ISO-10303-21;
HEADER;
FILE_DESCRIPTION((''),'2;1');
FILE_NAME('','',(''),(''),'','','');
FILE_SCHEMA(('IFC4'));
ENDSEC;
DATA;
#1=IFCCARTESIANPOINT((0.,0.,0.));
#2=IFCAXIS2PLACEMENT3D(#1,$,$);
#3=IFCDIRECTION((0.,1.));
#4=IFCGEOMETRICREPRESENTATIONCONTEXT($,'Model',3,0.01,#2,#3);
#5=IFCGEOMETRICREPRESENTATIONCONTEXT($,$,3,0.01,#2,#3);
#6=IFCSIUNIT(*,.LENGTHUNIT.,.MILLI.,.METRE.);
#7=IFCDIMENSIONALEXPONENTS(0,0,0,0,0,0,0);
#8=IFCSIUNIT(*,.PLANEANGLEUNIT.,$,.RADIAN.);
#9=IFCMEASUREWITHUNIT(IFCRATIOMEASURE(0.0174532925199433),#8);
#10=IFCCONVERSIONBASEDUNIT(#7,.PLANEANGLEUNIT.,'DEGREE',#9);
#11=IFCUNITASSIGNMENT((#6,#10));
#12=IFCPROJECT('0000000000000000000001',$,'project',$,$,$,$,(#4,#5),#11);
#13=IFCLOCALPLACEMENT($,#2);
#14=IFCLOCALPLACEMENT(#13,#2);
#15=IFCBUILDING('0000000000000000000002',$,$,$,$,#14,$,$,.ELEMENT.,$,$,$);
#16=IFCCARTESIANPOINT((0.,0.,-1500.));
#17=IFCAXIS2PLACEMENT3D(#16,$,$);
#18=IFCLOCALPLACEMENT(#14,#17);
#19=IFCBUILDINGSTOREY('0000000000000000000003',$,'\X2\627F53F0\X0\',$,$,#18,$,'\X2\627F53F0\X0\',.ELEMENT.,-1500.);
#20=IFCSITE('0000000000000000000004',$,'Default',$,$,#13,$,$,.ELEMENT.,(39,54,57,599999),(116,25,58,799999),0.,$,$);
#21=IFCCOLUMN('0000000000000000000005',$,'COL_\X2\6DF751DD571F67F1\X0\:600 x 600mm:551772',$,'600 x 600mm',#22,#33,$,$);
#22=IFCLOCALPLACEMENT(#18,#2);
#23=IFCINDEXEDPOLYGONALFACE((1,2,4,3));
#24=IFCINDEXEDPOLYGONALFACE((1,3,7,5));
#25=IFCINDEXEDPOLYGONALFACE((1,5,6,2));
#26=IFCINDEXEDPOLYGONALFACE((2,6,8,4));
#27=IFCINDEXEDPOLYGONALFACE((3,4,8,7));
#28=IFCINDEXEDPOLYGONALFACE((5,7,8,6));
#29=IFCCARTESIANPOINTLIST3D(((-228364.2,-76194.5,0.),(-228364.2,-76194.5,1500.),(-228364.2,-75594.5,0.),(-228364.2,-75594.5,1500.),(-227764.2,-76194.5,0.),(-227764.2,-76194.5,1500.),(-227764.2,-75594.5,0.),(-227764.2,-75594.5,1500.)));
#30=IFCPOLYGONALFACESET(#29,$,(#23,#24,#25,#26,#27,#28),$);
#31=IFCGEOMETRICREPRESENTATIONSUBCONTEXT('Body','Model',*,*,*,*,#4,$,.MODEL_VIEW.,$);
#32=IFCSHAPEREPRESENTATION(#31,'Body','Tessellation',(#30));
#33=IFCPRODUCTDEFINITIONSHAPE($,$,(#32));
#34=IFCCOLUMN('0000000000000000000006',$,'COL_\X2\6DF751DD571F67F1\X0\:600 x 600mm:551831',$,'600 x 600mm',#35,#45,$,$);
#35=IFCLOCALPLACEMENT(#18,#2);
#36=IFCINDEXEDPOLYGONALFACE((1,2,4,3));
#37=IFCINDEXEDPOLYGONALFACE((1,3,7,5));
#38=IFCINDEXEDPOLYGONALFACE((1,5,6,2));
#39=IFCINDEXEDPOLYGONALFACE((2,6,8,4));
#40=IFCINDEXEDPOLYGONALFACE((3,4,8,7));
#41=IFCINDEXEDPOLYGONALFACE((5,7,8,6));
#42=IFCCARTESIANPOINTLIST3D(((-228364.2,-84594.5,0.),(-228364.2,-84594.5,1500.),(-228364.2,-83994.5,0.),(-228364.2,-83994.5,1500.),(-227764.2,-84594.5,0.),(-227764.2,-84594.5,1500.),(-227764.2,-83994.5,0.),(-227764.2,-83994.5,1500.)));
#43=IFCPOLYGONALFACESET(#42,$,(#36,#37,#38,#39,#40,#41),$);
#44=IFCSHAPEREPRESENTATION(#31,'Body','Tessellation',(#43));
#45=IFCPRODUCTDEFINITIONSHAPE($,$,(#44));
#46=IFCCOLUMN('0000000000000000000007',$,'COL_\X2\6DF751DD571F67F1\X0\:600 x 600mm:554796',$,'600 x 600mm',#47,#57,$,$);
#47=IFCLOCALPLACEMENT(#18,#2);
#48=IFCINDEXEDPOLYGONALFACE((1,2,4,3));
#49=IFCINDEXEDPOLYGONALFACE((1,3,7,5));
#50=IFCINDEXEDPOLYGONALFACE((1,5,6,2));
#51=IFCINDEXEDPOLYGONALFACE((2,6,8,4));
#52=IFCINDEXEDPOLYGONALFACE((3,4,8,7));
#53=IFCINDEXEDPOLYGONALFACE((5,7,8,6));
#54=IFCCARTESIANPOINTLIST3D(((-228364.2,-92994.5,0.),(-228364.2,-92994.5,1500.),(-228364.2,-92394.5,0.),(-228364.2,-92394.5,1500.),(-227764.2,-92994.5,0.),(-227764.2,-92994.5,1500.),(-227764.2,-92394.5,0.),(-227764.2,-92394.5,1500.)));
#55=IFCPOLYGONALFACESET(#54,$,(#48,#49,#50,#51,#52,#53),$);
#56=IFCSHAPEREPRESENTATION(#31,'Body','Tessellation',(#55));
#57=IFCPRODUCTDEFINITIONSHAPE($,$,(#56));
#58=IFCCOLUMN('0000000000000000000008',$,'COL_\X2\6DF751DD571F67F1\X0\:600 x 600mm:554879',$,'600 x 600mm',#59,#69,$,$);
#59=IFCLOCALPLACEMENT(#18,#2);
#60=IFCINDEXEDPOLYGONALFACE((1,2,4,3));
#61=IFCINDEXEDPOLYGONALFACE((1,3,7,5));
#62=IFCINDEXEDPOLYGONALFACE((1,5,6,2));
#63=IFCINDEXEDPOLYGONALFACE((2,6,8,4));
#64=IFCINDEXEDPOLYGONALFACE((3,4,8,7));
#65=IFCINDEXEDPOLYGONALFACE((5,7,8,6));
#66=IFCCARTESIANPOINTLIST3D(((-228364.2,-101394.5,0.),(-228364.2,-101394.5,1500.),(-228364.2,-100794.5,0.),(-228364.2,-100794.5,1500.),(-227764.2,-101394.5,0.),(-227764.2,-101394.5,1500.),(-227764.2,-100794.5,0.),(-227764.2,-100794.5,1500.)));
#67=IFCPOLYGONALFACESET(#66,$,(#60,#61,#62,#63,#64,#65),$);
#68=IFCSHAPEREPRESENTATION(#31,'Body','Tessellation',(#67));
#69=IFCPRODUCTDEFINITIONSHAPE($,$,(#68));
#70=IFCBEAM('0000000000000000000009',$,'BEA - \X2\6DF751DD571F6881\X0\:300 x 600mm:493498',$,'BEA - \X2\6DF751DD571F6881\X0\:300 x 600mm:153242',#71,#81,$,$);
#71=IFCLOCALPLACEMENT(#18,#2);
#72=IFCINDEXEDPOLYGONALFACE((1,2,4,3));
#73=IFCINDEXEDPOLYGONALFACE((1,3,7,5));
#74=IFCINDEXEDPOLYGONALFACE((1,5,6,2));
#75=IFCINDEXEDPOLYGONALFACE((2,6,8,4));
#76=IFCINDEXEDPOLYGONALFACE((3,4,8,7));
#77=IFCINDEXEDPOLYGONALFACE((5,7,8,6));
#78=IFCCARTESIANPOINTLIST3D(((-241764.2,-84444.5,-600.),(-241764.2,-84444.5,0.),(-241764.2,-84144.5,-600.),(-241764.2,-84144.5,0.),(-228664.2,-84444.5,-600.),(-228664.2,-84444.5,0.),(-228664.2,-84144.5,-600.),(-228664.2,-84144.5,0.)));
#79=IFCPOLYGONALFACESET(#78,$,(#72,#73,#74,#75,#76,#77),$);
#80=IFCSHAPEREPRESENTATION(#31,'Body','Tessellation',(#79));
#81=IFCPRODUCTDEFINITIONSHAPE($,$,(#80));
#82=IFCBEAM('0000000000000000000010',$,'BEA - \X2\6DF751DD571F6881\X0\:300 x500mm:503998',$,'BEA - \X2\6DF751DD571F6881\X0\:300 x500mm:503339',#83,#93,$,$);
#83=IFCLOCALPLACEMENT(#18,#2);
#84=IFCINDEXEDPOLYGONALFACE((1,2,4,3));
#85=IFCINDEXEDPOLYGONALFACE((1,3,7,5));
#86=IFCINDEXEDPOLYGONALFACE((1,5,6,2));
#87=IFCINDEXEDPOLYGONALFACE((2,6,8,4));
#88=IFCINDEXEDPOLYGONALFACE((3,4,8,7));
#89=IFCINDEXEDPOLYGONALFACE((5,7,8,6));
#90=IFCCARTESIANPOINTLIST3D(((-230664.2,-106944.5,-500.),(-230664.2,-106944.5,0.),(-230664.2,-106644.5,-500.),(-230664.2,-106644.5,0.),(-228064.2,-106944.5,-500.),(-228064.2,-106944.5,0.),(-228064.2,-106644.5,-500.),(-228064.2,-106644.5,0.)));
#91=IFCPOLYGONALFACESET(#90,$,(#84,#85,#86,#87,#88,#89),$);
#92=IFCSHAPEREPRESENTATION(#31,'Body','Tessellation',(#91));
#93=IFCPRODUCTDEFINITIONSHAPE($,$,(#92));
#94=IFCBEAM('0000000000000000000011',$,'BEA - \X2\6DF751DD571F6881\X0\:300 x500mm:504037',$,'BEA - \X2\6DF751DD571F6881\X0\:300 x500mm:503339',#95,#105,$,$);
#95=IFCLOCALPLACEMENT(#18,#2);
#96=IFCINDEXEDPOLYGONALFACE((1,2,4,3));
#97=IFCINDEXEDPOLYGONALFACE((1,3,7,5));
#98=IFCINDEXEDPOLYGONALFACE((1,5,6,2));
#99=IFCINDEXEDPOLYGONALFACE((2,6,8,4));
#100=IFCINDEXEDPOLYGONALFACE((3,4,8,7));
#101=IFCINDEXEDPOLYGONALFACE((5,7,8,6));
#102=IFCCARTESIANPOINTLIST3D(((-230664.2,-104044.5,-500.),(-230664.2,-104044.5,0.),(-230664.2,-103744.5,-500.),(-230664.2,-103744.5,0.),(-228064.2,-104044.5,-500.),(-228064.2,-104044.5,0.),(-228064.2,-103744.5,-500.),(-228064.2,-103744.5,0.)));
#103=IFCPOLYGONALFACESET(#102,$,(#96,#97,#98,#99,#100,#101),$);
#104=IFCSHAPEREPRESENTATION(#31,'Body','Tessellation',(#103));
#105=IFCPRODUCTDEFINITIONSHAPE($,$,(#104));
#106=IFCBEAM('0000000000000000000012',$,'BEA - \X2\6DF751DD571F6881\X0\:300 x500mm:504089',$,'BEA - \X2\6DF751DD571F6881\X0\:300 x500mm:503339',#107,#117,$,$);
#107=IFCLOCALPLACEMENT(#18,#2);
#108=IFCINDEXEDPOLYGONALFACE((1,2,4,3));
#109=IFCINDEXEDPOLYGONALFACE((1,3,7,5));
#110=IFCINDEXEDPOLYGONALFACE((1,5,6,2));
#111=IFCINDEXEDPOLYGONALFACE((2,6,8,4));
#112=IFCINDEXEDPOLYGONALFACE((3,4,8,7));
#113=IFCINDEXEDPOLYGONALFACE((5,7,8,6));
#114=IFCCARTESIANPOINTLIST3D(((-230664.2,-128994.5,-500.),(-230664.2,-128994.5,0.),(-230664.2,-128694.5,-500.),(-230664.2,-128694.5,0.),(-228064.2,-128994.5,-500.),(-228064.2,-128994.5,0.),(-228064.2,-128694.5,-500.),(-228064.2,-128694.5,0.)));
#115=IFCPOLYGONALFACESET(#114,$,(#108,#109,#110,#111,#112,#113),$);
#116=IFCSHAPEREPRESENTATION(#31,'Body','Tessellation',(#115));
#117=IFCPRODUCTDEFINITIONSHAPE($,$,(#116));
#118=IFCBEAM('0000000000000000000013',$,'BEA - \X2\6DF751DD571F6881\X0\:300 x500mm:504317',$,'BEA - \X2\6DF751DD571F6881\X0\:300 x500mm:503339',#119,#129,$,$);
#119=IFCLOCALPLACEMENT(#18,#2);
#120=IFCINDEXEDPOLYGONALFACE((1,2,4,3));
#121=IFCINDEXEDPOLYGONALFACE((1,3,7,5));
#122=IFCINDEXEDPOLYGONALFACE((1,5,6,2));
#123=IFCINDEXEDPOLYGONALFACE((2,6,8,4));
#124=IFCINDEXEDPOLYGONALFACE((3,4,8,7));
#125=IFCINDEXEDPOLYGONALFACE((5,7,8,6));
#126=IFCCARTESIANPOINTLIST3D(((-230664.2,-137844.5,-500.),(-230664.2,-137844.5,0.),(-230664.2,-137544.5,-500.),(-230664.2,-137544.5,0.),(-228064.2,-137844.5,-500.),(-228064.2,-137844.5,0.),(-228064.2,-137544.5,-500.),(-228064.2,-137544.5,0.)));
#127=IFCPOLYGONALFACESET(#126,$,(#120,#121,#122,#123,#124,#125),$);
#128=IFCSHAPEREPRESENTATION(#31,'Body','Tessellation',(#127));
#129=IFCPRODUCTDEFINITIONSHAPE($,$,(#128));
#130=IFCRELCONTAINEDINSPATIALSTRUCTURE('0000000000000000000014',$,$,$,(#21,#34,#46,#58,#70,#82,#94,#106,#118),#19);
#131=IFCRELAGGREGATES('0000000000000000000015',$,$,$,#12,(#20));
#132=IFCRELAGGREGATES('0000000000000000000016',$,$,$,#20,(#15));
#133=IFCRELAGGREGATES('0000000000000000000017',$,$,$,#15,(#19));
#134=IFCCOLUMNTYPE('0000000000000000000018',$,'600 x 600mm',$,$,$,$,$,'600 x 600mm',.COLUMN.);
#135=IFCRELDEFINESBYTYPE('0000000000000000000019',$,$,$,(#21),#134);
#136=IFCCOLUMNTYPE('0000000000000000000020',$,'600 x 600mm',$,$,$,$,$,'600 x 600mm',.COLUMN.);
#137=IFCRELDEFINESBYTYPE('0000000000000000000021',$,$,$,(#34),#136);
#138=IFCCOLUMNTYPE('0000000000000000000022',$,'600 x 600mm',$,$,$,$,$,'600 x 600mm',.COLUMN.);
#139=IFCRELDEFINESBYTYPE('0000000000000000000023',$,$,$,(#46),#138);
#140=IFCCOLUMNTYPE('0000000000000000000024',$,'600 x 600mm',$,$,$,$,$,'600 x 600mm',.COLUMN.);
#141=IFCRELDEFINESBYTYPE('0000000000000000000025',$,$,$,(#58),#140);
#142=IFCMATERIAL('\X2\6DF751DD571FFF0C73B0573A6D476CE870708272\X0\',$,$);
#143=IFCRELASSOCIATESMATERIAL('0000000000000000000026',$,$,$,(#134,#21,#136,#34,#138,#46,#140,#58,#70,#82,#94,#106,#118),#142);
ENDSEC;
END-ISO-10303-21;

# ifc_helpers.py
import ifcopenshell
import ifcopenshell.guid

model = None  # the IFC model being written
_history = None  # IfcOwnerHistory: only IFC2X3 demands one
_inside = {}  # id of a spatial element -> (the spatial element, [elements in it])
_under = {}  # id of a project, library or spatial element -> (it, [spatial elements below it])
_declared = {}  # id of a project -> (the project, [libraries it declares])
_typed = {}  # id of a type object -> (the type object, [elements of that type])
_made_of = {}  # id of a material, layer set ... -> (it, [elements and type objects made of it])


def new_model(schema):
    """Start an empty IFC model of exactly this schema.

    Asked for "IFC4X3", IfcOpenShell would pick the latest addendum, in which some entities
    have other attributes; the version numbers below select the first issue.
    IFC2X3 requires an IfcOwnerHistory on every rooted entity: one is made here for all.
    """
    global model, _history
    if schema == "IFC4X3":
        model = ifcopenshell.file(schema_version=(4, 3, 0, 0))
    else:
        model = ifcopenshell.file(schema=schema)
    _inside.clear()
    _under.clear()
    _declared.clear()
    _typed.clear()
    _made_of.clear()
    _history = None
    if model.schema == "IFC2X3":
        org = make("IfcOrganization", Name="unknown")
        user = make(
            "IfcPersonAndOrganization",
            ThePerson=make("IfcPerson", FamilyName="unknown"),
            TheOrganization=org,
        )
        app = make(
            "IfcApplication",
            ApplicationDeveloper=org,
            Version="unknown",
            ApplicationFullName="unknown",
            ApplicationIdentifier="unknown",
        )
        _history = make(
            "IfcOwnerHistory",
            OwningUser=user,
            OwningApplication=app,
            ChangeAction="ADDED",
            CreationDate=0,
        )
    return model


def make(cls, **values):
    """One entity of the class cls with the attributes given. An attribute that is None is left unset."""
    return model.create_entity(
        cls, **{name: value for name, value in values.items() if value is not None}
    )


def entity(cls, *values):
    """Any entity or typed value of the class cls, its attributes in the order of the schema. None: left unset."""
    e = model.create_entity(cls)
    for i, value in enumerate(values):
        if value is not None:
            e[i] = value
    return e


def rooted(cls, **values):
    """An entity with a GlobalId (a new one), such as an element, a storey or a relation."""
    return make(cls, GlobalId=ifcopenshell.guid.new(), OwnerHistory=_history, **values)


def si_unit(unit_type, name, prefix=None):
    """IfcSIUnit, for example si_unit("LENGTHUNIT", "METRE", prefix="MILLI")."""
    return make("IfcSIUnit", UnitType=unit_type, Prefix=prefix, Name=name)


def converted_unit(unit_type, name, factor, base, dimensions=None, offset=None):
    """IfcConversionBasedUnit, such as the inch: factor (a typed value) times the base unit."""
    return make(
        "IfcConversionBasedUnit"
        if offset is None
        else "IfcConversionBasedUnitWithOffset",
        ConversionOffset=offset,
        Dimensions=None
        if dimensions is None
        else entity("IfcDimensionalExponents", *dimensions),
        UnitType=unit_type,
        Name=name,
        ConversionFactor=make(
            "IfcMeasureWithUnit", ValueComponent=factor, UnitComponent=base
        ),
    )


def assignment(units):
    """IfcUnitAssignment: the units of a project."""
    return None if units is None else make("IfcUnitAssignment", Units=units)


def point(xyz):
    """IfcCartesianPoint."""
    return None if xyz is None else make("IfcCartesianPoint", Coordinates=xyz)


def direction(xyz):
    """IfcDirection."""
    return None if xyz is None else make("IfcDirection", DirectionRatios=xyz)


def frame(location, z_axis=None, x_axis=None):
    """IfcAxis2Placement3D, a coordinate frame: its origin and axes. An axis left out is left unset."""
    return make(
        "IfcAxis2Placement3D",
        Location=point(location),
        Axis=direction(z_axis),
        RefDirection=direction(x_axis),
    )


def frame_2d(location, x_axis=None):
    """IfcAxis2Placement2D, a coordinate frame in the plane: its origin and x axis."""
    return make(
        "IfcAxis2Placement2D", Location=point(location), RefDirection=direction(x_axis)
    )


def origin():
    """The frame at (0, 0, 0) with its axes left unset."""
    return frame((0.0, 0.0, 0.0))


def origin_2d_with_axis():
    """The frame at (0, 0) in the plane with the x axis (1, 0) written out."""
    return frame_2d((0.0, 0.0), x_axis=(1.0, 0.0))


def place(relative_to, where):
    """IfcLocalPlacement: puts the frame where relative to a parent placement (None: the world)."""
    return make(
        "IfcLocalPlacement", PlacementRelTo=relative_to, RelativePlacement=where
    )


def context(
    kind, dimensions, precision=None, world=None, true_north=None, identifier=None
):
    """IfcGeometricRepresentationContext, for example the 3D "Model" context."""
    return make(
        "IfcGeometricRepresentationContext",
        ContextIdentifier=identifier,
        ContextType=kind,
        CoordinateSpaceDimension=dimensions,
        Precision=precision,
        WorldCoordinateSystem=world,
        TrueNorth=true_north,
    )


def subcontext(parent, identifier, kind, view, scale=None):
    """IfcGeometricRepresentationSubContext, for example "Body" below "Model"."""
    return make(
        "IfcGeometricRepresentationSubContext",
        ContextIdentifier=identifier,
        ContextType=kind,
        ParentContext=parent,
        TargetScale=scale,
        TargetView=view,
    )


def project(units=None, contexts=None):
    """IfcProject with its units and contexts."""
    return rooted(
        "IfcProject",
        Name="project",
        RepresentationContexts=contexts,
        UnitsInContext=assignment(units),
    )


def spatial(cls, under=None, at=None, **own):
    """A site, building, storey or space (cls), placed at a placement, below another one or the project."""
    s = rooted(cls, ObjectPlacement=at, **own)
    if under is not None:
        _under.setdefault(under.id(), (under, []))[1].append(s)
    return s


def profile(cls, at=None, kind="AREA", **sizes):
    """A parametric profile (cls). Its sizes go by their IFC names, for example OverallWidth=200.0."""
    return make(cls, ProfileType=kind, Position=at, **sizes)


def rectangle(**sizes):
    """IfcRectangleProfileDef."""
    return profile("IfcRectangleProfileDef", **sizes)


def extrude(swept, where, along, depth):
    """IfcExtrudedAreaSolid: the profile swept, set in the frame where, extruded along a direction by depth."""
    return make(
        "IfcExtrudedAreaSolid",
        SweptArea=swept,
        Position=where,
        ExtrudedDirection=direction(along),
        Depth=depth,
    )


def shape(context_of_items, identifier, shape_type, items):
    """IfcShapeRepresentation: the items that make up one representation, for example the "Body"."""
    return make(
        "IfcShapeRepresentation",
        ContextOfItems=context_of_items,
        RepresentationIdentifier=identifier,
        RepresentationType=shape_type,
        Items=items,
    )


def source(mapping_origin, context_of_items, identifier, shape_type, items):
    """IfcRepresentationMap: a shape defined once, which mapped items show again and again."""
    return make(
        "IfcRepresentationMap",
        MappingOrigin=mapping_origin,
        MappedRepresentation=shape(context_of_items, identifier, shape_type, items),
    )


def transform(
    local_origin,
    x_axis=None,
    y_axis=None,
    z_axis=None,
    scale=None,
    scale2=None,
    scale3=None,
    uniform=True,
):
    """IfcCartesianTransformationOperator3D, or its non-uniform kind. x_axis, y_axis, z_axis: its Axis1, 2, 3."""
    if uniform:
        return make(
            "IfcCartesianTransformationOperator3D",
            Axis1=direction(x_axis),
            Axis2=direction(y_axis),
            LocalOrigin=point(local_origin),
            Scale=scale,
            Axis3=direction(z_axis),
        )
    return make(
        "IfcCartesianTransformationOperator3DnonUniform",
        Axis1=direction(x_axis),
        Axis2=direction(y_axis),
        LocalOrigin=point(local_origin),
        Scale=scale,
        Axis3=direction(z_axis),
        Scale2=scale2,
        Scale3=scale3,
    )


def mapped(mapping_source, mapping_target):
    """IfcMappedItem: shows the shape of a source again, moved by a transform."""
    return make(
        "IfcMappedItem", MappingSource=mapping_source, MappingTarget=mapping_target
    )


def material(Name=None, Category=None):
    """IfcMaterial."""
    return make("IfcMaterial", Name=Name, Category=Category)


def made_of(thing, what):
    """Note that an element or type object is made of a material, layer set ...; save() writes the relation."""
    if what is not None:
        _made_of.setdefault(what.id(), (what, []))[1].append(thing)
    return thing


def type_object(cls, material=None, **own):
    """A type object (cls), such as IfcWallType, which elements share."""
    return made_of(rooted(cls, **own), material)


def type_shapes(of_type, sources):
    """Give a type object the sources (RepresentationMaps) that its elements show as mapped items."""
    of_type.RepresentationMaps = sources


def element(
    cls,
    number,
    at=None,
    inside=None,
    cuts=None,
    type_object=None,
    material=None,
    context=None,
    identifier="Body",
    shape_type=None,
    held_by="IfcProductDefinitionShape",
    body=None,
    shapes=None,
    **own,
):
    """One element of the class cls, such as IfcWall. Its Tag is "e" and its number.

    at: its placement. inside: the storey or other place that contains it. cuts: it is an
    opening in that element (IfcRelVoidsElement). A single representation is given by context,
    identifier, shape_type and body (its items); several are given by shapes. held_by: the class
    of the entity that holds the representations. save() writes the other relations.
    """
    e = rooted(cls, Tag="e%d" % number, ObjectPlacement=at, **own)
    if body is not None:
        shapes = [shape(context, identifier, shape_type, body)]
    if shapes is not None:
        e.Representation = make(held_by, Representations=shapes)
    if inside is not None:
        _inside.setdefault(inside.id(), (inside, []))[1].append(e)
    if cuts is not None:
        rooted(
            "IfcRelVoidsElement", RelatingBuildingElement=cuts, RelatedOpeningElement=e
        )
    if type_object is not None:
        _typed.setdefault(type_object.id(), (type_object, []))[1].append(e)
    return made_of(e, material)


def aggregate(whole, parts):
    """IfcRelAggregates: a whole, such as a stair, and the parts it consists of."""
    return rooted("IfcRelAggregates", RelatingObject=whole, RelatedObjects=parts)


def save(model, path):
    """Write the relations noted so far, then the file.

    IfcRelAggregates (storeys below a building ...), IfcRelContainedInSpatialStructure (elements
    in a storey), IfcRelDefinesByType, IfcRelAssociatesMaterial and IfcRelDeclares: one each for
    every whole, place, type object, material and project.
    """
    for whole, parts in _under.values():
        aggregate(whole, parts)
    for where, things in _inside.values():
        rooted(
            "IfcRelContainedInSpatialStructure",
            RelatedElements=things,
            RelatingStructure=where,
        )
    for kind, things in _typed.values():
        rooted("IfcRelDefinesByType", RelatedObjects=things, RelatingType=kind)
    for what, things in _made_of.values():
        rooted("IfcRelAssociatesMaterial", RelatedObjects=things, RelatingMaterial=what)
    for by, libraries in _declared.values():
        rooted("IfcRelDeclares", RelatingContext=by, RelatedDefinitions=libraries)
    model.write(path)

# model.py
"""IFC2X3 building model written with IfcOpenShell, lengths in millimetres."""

from ifc_helpers import new_model, entity, si_unit, converted_unit, direction, frame, frame_2d, origin, origin_2d_with_axis, place, context, subcontext, project, spatial, rectangle, extrude, source, transform, mapped, material, type_object, type_shapes, element, save


model = new_model("IFC2X3")

# Units and contexts
model_context = context("Model", 3, precision=0.01, world=origin(), true_north=direction((0.0, 1.0)))
context_of_model = context(None, 3, precision=0.01, world=origin(), true_north=direction((0.0, 1.0)))
body_context = subcontext(model_context, "Body", "Model", "MODEL_VIEW")
ifc_project = project(units=[si_unit("LENGTHUNIT", "METRE", prefix="MILLI"), converted_unit("PLANEANGLEUNIT", "DEGREE", entity("IfcRatioMeasure", 0.0174532925199433), si_unit("PLANEANGLEUNIT", "RADIAN"), dimensions=[0, 0, 0, 0, 0, 0, 0])], contexts=[model_context, context_of_model])

# Site, building, storey
site_placement = place(None, origin())
site = spatial("IfcSite", under=ifc_project, at=site_placement, Name="Default", CompositionType="ELEMENT", RefLatitude=(39, 54, 57, 599999), RefLongitude=(116, 25, 58, 799999), RefElevation=0.0)
building_placement = place(site_placement, origin())
building = spatial("IfcBuilding", under=site, at=building_placement, CompositionType="ELEMENT")
storey_placement = place(building_placement, frame((0.0, 0.0, -1500.0)))
storey = spatial("IfcBuildingStorey", under=building, at=storey_placement, Name="承台", LongName="承台", CompositionType="ELEMENT", Elevation=-1500.0)

# Columns
ifc_material_1 = material(Name="混凝土，现场浇注灰色")
column_type_1 = type_object("IfcColumnType", Name="600 x 600mm", ElementType="600 x 600mm", PredefinedType="COLUMN", material=ifc_material_1)
shared_shape_1 = source(origin(), body_context, "Body", "SweptSolid", [
    extrude(rectangle(XDim=600.0, YDim=600.0, at=origin_2d_with_axis()), frame((300.0, 300.0, 0.0), z_axis=(0.0, 0.0, 1.0), x_axis=(-1.0, 0.0, 0.0)), (0.0, 0.0, 1.0), 1500.0),
])
type_shapes(column_type_1, [shared_shape_1])
column_1_placement = place(storey_placement, frame((-228364.2, -76194.5, 0.0)))
element("IfcColumn", 1, at=column_1_placement, inside=storey, type_object=column_type_1, material=ifc_material_1, Name="COL_混凝土柱:600 x 600mm:551772", ObjectType="600 x 600mm", context=body_context, shape_type="MappedRepresentation", body=[
    mapped(shared_shape_1, transform((0.0, 0.0, 0.0), scale=1.0)),
])
column_type_2 = type_object("IfcColumnType", Name="600 x 600mm", ElementType="600 x 600mm", PredefinedType="COLUMN", material=ifc_material_1)
shared_shape_2 = source(origin(), body_context, "Body", "SweptSolid", [
    extrude(rectangle(XDim=600.0, YDim=600.0, at=origin_2d_with_axis()), frame((300.0, 300.0, 0.0), z_axis=(0.0, 0.0, 1.0), x_axis=(-1.0, 0.0, 0.0)), (0.0, 0.0, 1.0), 1500.0),
])
type_shapes(column_type_2, [shared_shape_2])
column_2_placement = place(storey_placement, frame((-228364.2, -84594.5, 0.0)))
element("IfcColumn", 2, at=column_2_placement, inside=storey, type_object=column_type_2, material=ifc_material_1, Name="COL_混凝土柱:600 x 600mm:551831", ObjectType="600 x 600mm", context=body_context, shape_type="MappedRepresentation", body=[
    mapped(shared_shape_2, transform((0.0, 0.0, 0.0), scale=1.0)),
])
column_type_3 = type_object("IfcColumnType", Name="600 x 600mm", ElementType="600 x 600mm", PredefinedType="COLUMN", material=ifc_material_1)
shared_shape_3 = source(origin(), body_context, "Body", "SweptSolid", [
    extrude(rectangle(XDim=600.0, YDim=600.0, at=origin_2d_with_axis()), frame((300.0, 300.0, 0.0), z_axis=(0.0, 0.0, 1.0), x_axis=(-1.0, 0.0, 0.0)), (0.0, 0.0, 1.0), 1500.0),
])
type_shapes(column_type_3, [shared_shape_3])
column_3_placement = place(storey_placement, frame((-228364.2, -92994.5, 0.0)))
element("IfcColumn", 3, at=column_3_placement, inside=storey, type_object=column_type_3, material=ifc_material_1, Name="COL_混凝土柱:600 x 600mm:554796", ObjectType="600 x 600mm", context=body_context, shape_type="MappedRepresentation", body=[
    mapped(shared_shape_3, transform((0.0, 0.0, 0.0), scale=1.0)),
])
column_type_4 = type_object("IfcColumnType", Name="600 x 600mm", ElementType="600 x 600mm", PredefinedType="COLUMN", material=ifc_material_1)
shared_shape_4 = source(origin(), body_context, "Body", "SweptSolid", [
    extrude(rectangle(XDim=600.0, YDim=600.0, at=origin_2d_with_axis()), frame((300.0, 300.0, 0.0), z_axis=(0.0, 0.0, 1.0), x_axis=(-1.0, 0.0, 0.0)), (0.0, 0.0, 1.0), 1500.0),
])
type_shapes(column_type_4, [shared_shape_4])
column_4_placement = place(storey_placement, frame((-228364.2, -101394.5, 0.0)))
element("IfcColumn", 4, at=column_4_placement, inside=storey, type_object=column_type_4, material=ifc_material_1, Name="COL_混凝土柱:600 x 600mm:554879", ObjectType="600 x 600mm", context=body_context, shape_type="MappedRepresentation", body=[
    mapped(shared_shape_4, transform((0.0, 0.0, 0.0), scale=1.0)),
])

# Beams
beam_1_placement = place(storey_placement, frame((-228664.2, -84294.5, 0.0), z_axis=(0.0, 0.0, 1.0), x_axis=(-1.0, 0.0, 0.0)))
element("IfcBeam", 5, at=beam_1_placement, inside=storey, material=ifc_material_1, Name="BEA - 混凝土梁:300 x 600mm:493498", ObjectType="BEA - 混凝土梁:300 x 600mm:153242", context=body_context, shape_type="SweptSolid", body=[
    extrude(rectangle(XDim=600.0, YDim=300.0, at=frame_2d((0.0, 0.0), x_axis=(1.0, 0.0))), frame((0.0, 0.0, -300.0), z_axis=(1.0, 0.0, 0.0), x_axis=(0.0, 0.0, -1.0)), (0.0, 0.0, 1.0), 13100.0),
])
for number, where, name in (
    (6, (-230664.2, -106794.5, 0.0), "BEA - 混凝土梁:300 x500mm:503998"),
    (7, (-230664.2, -103894.5, 0.0), "BEA - 混凝土梁:300 x500mm:504037"),
    (8, (-230664.2, -128844.5, 0.0), "BEA - 混凝土梁:300 x500mm:504089"),
    (9, (-230664.2, -137694.5, 0.0), "BEA - 混凝土梁:300 x500mm:504317"),
):
    element("IfcBeam", number, at=place(storey_placement, frame(where)), inside=storey, material=ifc_material_1, Name=name, ObjectType="BEA - 混凝土梁:300 x500mm:503339", context=body_context, shape_type="SweptSolid", body=[
        extrude(rectangle(XDim=500.0, YDim=300.0, at=frame_2d((0.0, 0.0), x_axis=(1.0, 0.0))), frame((0.0, 0.0, -250.0), z_axis=(1.0, 0.0, 0.0), x_axis=(0.0, 0.0, -1.0)), (0.0, 0.0, 1.0), 2600.0),
    ])

save(model, "model.ifc")
